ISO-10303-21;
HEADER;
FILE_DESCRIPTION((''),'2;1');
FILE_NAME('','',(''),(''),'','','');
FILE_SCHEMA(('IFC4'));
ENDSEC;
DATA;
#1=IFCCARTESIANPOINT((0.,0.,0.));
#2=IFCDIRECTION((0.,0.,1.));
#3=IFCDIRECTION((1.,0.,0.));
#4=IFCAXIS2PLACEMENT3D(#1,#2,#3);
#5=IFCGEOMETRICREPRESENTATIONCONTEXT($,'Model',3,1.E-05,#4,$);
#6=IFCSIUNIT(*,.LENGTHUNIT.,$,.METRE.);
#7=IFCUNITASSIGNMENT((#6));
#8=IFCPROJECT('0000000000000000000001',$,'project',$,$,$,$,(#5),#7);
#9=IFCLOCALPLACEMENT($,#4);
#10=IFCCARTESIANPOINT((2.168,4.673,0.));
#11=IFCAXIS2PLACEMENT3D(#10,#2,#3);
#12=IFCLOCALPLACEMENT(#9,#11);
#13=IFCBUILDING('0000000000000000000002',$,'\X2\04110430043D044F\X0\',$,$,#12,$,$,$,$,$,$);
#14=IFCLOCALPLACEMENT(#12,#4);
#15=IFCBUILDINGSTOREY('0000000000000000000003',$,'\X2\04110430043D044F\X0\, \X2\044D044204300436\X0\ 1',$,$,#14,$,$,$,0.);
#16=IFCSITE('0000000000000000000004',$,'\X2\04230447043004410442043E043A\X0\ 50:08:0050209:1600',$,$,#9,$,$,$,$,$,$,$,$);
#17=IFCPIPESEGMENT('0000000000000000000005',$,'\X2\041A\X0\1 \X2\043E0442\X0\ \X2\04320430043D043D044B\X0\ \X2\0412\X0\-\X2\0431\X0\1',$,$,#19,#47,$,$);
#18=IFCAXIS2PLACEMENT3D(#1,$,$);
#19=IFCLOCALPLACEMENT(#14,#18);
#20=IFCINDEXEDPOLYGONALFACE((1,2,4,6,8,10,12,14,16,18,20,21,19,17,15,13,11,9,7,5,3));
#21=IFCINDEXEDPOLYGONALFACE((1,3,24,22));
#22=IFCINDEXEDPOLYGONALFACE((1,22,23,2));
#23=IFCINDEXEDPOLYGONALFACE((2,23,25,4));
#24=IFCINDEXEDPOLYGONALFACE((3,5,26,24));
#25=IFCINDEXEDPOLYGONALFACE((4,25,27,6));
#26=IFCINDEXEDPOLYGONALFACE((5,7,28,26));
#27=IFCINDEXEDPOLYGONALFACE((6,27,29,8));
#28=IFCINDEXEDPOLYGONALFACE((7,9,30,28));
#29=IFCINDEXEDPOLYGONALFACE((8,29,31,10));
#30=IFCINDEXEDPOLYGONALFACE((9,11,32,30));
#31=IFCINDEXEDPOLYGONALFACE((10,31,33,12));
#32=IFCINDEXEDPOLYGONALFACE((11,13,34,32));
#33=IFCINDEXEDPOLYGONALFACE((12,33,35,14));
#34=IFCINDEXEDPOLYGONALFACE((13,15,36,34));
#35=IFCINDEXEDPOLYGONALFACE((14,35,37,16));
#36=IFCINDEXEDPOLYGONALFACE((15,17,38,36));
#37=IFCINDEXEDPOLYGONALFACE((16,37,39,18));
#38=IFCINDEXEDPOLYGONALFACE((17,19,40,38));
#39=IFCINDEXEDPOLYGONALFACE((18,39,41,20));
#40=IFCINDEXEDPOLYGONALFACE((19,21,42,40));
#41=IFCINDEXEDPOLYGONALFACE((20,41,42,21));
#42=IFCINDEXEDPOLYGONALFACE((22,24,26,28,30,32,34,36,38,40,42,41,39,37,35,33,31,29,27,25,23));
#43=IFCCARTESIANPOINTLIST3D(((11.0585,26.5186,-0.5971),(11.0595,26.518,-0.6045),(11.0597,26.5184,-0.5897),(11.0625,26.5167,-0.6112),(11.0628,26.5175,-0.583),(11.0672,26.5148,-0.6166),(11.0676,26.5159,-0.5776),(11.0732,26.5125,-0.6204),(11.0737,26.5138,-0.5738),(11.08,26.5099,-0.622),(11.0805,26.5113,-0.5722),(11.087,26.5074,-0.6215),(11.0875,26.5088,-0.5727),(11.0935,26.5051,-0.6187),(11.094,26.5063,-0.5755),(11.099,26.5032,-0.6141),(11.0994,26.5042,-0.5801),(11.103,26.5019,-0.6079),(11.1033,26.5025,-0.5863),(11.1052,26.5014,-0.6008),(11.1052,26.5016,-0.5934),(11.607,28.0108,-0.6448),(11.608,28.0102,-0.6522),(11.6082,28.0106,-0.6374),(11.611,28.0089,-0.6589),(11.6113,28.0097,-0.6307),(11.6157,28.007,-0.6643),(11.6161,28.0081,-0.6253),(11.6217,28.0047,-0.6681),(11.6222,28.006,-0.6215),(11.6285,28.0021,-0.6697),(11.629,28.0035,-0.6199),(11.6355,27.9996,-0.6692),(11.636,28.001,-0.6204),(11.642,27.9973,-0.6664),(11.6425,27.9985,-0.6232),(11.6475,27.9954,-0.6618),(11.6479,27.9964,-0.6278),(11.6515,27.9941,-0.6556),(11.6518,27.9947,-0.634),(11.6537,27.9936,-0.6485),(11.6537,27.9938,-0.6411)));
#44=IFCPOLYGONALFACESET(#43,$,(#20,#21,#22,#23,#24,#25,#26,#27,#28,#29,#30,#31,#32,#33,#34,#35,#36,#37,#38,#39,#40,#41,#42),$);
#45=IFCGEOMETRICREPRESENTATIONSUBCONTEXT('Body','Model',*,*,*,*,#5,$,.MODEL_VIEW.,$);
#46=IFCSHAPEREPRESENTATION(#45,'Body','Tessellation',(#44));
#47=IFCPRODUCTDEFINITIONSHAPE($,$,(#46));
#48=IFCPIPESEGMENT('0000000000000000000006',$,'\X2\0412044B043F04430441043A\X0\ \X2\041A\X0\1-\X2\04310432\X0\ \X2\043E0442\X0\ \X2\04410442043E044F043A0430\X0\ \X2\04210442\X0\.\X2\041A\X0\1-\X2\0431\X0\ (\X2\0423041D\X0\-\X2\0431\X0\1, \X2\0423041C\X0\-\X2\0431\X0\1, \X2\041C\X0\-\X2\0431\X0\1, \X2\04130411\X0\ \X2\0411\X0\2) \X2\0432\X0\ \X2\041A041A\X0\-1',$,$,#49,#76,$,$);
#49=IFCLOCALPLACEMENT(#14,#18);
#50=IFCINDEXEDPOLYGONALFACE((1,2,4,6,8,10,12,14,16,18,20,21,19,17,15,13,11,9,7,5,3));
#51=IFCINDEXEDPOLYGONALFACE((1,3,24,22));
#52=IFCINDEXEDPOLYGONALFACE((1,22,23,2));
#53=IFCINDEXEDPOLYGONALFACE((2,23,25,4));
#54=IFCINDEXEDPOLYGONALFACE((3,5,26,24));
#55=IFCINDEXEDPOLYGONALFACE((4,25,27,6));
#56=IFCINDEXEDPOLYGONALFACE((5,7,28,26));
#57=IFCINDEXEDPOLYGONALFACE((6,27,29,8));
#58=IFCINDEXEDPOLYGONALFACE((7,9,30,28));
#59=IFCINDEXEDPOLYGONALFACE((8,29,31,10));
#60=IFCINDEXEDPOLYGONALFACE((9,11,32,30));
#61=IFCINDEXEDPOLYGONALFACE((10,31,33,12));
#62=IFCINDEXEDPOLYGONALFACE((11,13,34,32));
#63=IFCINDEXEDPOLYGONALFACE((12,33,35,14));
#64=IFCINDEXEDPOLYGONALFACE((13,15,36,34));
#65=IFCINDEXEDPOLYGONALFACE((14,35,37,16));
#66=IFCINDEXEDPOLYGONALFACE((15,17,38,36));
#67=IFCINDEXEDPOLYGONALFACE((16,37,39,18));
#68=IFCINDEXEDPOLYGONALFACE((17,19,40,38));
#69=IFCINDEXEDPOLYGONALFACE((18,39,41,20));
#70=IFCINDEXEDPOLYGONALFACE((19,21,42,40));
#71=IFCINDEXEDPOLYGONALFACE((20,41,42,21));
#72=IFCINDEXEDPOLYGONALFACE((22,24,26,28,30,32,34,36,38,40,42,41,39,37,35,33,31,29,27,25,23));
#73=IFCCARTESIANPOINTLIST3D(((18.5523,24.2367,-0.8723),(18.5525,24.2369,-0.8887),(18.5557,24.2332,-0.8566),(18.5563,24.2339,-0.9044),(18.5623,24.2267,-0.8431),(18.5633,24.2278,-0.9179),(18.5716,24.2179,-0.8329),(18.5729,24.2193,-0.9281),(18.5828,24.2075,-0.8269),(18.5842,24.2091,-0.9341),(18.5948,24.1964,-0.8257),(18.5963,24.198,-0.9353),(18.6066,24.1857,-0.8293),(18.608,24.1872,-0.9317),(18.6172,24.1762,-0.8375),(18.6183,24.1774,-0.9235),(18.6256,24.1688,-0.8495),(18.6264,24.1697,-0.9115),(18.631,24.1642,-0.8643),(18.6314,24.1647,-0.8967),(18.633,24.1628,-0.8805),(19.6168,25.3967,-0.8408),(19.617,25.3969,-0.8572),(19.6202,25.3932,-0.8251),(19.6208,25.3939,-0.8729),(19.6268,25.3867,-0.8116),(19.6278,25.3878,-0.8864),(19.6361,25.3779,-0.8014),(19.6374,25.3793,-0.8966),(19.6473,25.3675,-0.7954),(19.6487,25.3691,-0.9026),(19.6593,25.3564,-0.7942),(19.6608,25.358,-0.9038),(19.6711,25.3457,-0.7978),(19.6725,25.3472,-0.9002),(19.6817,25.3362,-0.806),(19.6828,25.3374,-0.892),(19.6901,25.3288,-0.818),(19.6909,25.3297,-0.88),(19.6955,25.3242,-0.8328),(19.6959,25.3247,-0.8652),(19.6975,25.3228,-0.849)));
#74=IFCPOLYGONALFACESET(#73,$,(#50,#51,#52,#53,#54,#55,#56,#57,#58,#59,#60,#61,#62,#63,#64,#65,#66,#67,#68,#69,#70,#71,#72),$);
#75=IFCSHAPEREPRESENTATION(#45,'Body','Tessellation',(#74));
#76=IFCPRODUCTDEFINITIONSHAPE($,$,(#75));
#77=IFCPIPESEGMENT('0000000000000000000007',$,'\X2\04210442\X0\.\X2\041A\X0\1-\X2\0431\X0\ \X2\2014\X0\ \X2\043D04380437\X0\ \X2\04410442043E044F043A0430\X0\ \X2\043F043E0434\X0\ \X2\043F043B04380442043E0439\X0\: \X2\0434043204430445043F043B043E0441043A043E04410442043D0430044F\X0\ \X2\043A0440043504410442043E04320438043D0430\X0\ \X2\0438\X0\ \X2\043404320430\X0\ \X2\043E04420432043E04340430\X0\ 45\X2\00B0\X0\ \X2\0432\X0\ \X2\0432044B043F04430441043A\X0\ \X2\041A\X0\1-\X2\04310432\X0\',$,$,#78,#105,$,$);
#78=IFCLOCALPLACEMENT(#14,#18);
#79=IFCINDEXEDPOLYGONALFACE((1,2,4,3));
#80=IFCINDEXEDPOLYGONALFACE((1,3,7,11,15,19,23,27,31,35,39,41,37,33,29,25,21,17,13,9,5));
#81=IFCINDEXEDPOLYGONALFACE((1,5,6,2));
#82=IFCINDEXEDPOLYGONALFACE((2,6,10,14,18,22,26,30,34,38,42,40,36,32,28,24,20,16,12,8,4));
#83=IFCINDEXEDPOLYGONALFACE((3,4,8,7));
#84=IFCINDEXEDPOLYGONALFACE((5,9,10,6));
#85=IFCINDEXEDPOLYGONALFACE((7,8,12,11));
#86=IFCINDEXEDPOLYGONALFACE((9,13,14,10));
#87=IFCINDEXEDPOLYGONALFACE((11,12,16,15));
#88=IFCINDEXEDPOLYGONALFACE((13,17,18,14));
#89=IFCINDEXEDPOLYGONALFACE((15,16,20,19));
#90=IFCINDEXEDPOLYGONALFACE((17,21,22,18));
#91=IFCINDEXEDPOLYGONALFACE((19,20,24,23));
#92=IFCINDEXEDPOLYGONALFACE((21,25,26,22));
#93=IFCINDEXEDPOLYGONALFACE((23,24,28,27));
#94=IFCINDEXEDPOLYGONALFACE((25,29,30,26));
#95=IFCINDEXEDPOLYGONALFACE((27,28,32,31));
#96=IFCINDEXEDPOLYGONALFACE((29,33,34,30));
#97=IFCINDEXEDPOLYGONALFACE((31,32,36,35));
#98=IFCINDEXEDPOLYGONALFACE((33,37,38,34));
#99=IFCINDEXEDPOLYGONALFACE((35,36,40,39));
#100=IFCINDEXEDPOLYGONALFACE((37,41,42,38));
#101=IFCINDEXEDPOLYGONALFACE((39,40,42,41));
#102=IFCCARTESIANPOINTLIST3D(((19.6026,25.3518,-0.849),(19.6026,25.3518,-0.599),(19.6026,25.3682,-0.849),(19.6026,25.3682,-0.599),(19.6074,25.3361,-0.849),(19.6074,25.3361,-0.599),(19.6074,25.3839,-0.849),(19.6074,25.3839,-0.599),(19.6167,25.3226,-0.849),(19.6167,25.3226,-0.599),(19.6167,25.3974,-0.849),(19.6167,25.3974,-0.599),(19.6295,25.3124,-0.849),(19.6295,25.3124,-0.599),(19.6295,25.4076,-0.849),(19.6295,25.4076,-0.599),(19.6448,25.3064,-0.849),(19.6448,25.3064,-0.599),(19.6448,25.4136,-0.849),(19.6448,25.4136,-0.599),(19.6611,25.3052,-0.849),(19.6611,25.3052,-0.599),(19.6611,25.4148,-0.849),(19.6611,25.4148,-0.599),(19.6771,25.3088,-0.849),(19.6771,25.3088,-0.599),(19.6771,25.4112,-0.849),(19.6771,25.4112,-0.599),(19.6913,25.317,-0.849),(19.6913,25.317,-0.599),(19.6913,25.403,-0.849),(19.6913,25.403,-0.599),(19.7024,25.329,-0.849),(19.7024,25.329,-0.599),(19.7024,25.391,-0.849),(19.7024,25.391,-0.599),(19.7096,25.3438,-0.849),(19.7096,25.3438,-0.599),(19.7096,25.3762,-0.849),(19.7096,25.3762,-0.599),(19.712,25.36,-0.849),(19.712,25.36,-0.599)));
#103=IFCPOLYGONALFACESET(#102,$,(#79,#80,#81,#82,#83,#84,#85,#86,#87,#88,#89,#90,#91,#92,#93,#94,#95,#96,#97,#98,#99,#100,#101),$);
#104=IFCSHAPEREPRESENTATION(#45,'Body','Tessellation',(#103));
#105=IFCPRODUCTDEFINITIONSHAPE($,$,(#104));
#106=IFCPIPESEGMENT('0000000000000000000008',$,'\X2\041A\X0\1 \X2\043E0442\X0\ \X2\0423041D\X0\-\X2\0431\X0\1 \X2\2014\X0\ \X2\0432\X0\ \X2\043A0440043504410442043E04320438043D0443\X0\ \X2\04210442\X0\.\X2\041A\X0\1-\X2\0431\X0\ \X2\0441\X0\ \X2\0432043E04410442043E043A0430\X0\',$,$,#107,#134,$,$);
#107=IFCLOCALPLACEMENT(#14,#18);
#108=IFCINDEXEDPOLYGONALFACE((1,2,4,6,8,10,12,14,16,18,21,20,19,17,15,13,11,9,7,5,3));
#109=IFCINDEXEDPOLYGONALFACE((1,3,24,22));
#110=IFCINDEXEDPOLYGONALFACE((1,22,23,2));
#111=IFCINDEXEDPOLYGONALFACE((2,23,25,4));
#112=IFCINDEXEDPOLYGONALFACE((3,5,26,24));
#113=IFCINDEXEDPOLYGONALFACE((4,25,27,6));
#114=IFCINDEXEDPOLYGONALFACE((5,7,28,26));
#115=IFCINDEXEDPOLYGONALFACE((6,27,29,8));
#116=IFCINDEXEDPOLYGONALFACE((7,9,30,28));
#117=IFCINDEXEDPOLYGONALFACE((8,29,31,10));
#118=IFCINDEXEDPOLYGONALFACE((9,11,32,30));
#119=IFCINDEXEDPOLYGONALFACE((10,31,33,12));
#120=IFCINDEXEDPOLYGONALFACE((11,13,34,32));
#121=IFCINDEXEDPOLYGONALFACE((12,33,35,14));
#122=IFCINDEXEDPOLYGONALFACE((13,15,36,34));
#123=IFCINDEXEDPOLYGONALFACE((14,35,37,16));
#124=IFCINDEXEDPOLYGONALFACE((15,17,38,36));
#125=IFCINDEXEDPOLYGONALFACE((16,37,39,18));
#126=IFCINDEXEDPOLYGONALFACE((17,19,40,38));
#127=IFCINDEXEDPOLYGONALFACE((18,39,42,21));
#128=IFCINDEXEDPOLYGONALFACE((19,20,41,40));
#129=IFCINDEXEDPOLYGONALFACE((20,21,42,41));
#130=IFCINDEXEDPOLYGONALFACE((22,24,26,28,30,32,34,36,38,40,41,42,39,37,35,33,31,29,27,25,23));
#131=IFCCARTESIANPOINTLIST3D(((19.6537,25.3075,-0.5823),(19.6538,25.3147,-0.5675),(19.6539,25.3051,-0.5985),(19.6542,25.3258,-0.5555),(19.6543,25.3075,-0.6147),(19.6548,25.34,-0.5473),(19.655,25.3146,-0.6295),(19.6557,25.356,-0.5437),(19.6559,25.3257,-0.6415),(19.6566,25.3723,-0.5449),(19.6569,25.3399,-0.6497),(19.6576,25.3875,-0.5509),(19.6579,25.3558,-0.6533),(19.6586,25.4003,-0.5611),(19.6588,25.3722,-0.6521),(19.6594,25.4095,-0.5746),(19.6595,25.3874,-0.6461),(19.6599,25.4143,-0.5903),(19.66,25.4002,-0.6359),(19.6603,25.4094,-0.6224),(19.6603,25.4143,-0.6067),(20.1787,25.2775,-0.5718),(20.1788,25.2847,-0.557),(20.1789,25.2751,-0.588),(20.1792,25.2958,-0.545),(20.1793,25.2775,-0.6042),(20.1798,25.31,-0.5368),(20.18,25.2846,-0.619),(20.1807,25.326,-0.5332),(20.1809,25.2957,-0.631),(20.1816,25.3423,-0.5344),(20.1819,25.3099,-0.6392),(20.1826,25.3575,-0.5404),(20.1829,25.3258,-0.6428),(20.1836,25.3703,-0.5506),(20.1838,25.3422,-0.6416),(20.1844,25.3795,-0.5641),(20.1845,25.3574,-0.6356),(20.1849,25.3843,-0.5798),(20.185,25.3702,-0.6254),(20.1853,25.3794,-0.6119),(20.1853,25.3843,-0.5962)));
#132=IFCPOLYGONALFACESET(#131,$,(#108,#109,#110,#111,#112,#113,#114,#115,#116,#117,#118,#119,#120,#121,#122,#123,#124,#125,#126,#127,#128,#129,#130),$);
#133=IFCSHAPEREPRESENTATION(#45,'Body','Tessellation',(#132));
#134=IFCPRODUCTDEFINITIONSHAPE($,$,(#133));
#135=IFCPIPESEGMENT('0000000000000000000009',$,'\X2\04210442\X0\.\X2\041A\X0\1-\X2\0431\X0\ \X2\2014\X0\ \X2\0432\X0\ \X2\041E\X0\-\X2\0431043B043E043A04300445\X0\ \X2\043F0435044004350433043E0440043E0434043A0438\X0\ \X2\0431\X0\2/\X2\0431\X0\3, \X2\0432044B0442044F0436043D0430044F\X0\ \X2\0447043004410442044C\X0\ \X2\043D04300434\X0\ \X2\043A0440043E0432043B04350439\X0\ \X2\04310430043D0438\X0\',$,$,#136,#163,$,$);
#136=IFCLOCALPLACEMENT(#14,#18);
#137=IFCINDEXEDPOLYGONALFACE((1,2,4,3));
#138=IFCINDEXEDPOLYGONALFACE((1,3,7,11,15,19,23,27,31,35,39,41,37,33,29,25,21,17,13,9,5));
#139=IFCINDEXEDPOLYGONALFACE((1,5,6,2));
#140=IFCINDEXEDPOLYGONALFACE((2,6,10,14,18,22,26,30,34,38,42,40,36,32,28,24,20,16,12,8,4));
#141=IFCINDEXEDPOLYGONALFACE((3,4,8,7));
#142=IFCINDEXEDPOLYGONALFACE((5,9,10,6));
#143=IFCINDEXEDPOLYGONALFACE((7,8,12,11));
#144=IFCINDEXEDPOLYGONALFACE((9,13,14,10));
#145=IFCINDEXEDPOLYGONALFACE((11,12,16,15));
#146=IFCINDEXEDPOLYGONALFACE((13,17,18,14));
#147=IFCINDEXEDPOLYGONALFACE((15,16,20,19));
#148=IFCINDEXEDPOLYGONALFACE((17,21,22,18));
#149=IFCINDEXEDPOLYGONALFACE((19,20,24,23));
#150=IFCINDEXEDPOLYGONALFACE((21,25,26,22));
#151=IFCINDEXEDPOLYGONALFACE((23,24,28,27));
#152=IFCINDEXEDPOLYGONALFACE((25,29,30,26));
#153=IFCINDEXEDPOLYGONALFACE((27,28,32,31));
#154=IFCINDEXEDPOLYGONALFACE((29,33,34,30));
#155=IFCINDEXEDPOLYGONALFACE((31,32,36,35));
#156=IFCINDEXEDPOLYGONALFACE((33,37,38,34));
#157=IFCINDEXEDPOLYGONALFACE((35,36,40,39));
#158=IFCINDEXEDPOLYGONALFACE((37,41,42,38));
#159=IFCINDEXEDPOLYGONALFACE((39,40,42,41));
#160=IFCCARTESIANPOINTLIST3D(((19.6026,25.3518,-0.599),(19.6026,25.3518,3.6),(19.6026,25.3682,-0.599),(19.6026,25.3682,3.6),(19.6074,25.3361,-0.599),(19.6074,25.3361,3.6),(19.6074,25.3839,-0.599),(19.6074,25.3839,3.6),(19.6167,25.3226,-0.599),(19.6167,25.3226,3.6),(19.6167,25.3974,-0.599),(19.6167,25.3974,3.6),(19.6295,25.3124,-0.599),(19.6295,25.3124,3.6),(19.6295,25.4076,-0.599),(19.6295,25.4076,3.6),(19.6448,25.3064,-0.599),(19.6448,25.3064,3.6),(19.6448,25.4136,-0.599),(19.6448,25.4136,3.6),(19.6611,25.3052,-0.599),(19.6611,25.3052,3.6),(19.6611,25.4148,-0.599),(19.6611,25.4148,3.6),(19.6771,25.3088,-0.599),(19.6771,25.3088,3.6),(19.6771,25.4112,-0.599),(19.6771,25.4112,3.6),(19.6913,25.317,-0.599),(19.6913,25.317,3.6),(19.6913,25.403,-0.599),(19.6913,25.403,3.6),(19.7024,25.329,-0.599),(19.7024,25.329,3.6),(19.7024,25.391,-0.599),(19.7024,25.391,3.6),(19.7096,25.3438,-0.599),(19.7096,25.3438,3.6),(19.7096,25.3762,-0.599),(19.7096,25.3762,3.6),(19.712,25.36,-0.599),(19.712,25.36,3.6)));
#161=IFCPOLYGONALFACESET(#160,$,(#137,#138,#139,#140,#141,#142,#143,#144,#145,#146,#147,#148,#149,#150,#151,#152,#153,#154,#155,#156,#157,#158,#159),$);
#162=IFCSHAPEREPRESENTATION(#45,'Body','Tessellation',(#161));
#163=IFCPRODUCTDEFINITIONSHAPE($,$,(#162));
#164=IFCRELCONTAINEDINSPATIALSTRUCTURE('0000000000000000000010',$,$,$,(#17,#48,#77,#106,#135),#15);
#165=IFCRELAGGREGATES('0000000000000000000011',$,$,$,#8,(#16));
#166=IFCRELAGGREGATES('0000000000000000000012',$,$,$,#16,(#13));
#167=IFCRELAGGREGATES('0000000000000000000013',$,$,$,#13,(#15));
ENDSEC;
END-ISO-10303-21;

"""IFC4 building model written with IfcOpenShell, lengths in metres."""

from ifc_helpers import new_model, si_unit, frame, origin_with_axes, origin_2d, place, context, subcontext, project, spatial, circle, extrude, element, save


model = new_model("IFC4")

# Units and contexts
model_context = context("Model", 3, precision=1e-05, world=origin_with_axes())
body_context = subcontext(model_context, "Body", "Model", "MODEL_VIEW")
ifc_project = project(units=[si_unit("LENGTHUNIT", "METRE")], contexts=[model_context])

# Site, building, storey
site_placement = place(None, origin_with_axes())
site = spatial("IfcSite", under=ifc_project, at=site_placement, Name="Участок 50:08:0050209:1600")
building_placement = place(site_placement, frame((2.168, 4.673, 0.0), z_axis=(0.0, 0.0, 1.0), x_axis=(1.0, 0.0, 0.0)))
building = spatial("IfcBuilding", under=site, at=building_placement, Name="Баня")
storey_placement = place(building_placement, origin_with_axes())
storey = spatial("IfcBuildingStorey", under=building, at=storey_placement, Name="Баня, этаж 1", Elevation=0.0)

# Pipe segments
pipe_segment_1_placement = place(storey_placement, origin_with_axes())
element("IfcPipeSegment", 1, at=pipe_segment_1_placement, inside=storey, Name="К1 от ванны В-б1", context=body_context, shape_type="SweptSolid", body=[
    extrude(circle(Radius=0.025, at=origin_2d()), frame((11.082, 26.51, -0.5971), z_axis=(0.344853, 0.938177, -0.02999), x_axis=(-0.9386, 0.345009, 0.0)), (0.0, 0.0, 1.0), 1.5905),
])
pipe_segment_2_placement = place(storey_placement, origin_with_axes())
element("IfcPipeSegment", 2, at=pipe_segment_2_placement, inside=storey, Name="Выпуск К1-бв от стояка Ст.К1-б (УН-б1, УМ-б1, М-б1, ГБ Б2) в КК-1", context=body_context, shape_type="SweptSolid", body=[
    extrude(circle(Radius=0.055, at=origin_2d()), frame((19.657, 25.36, -0.849), z_axis=(-0.675992, -0.736637, -0.020004), x_axis=(0.736785, -0.676127, 0.0)), (0.0, 0.0, 1.0), 1.5747),
])
pipe_segment_3_placement = place(storey_placement, origin_with_axes())
element("IfcPipeSegment", 3, at=pipe_segment_3_placement, inside=storey, Name="Ст.К1-б — низ стояка под плитой: двухплоскостная крестовина и два отвода 45° в выпуск К1-бв", context=body_context, shape_type="SweptSolid", body=[
    extrude(circle(Radius=0.055, at=origin_2d()), frame((19.657, 25.36, -0.849), z_axis=(0.0, 0.0, 1.0), x_axis=(1.0, 0.0, 0.0)), (0.0, 0.0, 1.0), 0.25),
])
pipe_segment_4_placement = place(storey_placement, origin_with_axes())
element("IfcPipeSegment", 4, at=pipe_segment_4_placement, inside=storey, Name="К1 от УН-б1 — в крестовину Ст.К1-б с востока", context=body_context, shape_type="SweptSolid", body=[
    extrude(circle(Radius=0.055, at=origin_2d()), frame((20.182, 25.33, -0.588), z_axis=(-0.998172, 0.057038, -0.019963), x_axis=(-0.05705, -0.998371, 0.0)), (0.0, 0.0, 1.0), 0.526),
])
pipe_segment_5_placement = place(storey_placement, origin_with_axes())
element("IfcPipeSegment", 5, at=pipe_segment_5_placement, inside=storey, Name="Ст.К1-б — в О-блоках перегородки б2/б3, вытяжная часть над кровлей бани", context=body_context, shape_type="SweptSolid", body=[
    extrude(circle(Radius=0.055, at=origin_2d()), frame((19.657, 25.36, -0.599), z_axis=(0.0, 0.0, 1.0), x_axis=(1.0, 0.0, 0.0)), (0.0, 0.0, 1.0), 4.199),
])

save(model, "model.ifc")
